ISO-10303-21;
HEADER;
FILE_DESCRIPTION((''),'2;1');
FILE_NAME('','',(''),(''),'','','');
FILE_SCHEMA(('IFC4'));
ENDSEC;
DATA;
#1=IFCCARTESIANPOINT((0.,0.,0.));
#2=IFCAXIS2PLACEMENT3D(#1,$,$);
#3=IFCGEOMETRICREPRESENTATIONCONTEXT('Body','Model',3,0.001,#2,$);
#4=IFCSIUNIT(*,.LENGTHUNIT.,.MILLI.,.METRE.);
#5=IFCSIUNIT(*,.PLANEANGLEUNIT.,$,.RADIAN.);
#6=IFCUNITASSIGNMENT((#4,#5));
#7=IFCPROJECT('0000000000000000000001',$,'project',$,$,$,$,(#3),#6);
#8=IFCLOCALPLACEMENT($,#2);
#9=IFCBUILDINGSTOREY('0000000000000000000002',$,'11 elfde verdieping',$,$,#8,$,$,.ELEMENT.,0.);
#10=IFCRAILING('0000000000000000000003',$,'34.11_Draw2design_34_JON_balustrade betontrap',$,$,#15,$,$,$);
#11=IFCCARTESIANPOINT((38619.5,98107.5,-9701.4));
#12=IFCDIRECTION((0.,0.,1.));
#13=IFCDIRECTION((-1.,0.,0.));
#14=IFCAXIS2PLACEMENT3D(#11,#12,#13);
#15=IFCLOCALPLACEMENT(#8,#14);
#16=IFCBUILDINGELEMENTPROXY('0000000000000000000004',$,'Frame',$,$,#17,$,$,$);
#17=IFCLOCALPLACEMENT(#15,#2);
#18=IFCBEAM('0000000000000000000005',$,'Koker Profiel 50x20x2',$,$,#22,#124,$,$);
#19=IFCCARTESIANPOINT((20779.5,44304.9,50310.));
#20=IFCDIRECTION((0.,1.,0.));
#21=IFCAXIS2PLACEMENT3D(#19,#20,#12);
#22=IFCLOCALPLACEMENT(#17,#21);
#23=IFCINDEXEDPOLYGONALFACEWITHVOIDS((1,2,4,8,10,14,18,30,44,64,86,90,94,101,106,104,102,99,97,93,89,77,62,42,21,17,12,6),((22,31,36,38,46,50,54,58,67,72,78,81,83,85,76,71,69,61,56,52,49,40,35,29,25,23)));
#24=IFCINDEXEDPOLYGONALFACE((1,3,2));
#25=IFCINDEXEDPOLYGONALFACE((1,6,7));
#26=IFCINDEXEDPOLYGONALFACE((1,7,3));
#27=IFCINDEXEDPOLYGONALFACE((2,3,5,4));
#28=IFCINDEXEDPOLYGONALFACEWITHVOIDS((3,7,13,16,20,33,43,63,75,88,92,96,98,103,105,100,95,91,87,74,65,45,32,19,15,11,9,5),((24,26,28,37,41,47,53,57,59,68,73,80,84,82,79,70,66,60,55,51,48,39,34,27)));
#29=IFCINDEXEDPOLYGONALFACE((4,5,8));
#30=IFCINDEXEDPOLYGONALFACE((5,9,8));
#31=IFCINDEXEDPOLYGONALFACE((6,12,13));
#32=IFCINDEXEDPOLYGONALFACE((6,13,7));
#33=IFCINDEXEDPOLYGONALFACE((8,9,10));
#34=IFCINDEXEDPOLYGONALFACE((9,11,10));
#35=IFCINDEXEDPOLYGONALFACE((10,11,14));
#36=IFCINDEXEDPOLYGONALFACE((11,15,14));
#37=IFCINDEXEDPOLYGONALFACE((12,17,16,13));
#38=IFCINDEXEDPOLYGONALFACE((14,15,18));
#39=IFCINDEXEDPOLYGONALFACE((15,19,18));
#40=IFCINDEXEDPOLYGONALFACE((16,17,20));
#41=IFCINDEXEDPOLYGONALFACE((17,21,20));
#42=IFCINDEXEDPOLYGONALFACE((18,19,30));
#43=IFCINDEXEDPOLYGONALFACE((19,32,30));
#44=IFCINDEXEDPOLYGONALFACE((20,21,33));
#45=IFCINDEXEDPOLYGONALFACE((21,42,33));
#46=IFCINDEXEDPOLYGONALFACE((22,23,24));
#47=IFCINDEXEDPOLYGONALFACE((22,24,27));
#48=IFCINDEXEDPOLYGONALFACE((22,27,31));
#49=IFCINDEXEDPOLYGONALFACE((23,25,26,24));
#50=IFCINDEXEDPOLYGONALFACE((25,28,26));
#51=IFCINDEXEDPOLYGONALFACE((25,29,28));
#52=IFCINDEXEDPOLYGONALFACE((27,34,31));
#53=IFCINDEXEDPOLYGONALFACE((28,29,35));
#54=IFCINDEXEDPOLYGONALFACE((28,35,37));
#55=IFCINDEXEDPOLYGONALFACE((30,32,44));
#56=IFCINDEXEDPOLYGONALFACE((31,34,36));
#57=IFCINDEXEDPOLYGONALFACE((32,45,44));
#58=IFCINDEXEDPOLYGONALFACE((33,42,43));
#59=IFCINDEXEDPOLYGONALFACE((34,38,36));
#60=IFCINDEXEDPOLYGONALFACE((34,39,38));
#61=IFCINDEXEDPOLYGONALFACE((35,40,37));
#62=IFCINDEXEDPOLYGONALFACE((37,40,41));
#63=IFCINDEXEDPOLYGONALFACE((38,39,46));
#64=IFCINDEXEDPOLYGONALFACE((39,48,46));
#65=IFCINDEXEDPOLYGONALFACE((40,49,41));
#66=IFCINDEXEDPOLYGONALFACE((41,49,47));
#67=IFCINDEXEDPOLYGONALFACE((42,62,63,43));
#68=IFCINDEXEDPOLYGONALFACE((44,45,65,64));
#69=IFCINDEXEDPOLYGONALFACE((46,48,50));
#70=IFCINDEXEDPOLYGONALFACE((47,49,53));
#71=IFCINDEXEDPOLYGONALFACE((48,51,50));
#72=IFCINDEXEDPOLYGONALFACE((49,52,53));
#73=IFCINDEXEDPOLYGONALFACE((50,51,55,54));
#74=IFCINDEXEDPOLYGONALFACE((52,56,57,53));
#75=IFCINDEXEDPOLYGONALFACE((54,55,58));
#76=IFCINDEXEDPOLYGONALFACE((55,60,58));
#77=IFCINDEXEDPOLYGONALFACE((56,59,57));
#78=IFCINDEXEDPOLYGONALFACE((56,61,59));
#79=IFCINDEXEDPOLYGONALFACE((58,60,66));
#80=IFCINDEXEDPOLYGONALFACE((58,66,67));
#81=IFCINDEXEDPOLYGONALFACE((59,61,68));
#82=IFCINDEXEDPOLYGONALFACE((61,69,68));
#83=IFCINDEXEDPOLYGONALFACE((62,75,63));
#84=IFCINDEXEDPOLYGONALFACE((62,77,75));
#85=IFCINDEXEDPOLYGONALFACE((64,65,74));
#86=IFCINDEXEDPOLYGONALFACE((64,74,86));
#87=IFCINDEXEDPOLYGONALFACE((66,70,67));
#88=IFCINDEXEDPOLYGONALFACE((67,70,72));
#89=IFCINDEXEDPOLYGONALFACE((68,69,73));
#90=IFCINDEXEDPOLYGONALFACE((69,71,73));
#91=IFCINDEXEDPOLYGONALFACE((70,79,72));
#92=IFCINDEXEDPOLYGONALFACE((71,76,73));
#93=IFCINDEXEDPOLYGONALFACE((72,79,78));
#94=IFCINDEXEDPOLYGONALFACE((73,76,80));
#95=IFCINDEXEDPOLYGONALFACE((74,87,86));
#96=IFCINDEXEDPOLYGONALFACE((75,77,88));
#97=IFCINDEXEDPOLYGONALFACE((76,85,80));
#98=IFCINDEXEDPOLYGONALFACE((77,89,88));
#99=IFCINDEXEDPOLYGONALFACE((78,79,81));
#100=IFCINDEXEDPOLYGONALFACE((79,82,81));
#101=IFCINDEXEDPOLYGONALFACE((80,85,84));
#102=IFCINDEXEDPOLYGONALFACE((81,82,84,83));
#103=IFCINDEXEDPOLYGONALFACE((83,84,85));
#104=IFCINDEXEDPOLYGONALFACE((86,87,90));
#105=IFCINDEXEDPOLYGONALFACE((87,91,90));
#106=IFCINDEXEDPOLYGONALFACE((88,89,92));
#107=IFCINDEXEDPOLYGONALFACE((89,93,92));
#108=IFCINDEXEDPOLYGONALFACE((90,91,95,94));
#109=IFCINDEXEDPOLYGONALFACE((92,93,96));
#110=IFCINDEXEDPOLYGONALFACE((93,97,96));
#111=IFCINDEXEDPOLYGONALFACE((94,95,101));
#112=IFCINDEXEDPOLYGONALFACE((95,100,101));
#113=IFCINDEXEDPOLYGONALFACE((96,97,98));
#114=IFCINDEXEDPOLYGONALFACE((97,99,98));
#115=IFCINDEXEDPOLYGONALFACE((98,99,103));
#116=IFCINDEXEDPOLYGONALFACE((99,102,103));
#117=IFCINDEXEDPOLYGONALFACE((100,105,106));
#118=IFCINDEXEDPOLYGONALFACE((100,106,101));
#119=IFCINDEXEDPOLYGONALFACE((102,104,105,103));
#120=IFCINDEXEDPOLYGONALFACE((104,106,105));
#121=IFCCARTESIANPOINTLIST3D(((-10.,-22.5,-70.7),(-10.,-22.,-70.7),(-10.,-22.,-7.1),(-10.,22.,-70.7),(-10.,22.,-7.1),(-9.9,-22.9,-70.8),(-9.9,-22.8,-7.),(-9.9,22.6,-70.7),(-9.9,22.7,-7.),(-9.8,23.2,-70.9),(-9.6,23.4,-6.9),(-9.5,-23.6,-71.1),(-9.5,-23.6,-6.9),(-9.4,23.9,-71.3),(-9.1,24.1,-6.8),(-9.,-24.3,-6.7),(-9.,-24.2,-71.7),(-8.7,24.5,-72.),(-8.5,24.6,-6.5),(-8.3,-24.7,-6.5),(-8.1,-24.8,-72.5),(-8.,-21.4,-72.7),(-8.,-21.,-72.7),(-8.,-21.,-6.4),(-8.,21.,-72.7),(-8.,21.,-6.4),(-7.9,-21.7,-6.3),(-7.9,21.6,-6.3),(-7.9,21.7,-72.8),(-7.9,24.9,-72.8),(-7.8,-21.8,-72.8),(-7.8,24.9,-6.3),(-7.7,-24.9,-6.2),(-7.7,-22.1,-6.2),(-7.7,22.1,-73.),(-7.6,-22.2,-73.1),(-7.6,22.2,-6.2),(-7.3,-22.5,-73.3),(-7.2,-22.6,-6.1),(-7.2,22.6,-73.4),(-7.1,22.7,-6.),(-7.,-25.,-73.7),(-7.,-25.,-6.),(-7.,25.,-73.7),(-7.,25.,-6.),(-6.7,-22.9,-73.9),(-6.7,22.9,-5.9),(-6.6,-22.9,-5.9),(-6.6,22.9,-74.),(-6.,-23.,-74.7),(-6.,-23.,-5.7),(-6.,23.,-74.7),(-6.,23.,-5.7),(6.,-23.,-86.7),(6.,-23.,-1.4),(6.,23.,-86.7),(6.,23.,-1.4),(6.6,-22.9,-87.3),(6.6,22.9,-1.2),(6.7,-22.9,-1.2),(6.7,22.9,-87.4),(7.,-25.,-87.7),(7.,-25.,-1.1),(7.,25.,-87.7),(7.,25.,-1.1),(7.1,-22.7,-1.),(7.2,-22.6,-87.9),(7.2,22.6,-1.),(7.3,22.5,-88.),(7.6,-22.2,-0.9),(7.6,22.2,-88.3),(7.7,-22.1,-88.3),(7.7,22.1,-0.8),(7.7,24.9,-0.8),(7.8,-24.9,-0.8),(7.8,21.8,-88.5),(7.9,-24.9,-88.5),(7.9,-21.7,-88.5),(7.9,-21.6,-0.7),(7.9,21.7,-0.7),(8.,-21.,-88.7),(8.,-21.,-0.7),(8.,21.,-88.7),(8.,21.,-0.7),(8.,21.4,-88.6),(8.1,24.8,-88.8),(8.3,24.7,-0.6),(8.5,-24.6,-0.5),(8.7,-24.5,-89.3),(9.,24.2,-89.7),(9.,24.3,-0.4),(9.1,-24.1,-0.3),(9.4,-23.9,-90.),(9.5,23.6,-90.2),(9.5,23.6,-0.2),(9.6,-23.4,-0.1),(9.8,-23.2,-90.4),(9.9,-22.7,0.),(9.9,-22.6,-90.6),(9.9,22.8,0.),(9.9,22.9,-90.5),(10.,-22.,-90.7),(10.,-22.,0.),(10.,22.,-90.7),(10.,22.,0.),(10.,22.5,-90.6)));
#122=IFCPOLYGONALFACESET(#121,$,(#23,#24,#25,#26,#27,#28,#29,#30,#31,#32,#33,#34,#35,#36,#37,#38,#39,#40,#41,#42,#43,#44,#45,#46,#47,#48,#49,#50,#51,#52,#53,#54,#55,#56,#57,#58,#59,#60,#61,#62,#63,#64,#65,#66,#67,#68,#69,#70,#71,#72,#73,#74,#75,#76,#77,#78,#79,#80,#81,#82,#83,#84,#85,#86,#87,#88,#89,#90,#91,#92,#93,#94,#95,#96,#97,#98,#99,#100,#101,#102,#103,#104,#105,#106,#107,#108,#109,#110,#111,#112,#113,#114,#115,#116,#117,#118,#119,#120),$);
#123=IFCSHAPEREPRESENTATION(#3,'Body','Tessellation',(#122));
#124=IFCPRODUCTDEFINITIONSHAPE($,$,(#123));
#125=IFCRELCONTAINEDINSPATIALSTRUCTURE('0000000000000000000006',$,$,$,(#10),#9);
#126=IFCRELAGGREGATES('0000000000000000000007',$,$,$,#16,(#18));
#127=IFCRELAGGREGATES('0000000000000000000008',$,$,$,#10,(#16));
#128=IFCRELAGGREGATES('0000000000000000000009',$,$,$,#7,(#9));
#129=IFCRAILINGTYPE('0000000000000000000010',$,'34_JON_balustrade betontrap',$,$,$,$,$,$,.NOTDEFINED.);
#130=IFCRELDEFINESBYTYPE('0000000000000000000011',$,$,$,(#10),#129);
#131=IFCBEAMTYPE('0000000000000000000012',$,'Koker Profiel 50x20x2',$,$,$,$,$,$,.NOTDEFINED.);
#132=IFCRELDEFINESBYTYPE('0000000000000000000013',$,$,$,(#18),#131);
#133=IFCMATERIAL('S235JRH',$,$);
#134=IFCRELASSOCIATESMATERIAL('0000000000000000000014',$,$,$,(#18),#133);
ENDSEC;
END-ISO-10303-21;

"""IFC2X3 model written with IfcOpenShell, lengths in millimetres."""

from ifc_helpers import new_model, si_unit, frame, origin, origin_2d, place, context, project, spatial, hollow_rectangle, extrude, clip, halfspace, source, transform, mapped, material, type_object, element, aggregate, save


model = new_model("IFC2X3")

# Units and contexts
model_context = context("Model", 3, precision=0.001, world=origin(), identifier="Body")
ifc_project = project(units=[si_unit("LENGTHUNIT", "METRE", prefix="MILLI"), si_unit("PLANEANGLEUNIT", "RADIAN")], contexts=[model_context])

# Storey
storey_placement = place(None, origin())
storey = spatial("IfcBuildingStorey", under=ifc_project, at=storey_placement, Name="11 elfde verdieping", CompositionType="ELEMENT", Elevation=0.0)

# Railing, building element proxy, beam
railing_type = type_object("IfcRailingType", Name="34_JON_balustrade betontrap")
railing_placement = place(storey_placement, frame((38619.5, 98107.5, -9701.4), z_axis=(0.0, 0.0, 1.0), x_axis=(-1.0, 0.0, 0.0)))
railing = element("IfcRailing", 1, at=railing_placement, inside=storey, type_object=railing_type, Name="34.11_Draw2design_34_JON_balustrade betontrap")
ifc_material_1 = material(Name="S235JRH")
proxy_1_placement = place(railing_placement, origin())
proxy_1 = element("IfcBuildingElementProxy", 2, at=proxy_1_placement, Name="Frame")
beam_type_1 = type_object("IfcBeamType", Name="Koker Profiel 50x20x2")
shared_shape_1 = source(origin(), model_context, "Body", "Clipping", [
    clip(clip(extrude(hollow_rectangle(XDim=20.0, YDim=50.0, WallThickness=2.0, InnerFilletRadius=2.0, OuterFilletRadius=3.0, at=origin_2d()), origin(), (0.0, 0.0, -1.0), 90.7), halfspace(frame((-10.0, 25.0, -7.1), z_axis=(-0.33335, 0.0, 0.942803), x_axis=(0.0, 1.0, 0.0)), False)), halfspace(frame((-10.0, -25.0, -70.7), z_axis=(-0.707107, 0.0, -0.707107), x_axis=(0.0, -1.0, 0.0)), False)),
])
beam_1_placement = place(proxy_1_placement, frame((20779.5, 44304.9, 50310.0), z_axis=(0.0, 1.0, 0.0), x_axis=(0.0, 0.0, 1.0)))
beam_1 = element("IfcBeam", 3, at=beam_1_placement, type_object=beam_type_1, material=ifc_material_1, Name="Koker Profiel 50x20x2", context=model_context, shape_type="MappedRepresentation", body=[
    mapped(shared_shape_1, transform((0.0, 0.0, 0.0), scale=1.0)),
])
aggregate(proxy_1, [beam_1])
aggregate(railing, [proxy_1])

save(model, "model.ifc")
